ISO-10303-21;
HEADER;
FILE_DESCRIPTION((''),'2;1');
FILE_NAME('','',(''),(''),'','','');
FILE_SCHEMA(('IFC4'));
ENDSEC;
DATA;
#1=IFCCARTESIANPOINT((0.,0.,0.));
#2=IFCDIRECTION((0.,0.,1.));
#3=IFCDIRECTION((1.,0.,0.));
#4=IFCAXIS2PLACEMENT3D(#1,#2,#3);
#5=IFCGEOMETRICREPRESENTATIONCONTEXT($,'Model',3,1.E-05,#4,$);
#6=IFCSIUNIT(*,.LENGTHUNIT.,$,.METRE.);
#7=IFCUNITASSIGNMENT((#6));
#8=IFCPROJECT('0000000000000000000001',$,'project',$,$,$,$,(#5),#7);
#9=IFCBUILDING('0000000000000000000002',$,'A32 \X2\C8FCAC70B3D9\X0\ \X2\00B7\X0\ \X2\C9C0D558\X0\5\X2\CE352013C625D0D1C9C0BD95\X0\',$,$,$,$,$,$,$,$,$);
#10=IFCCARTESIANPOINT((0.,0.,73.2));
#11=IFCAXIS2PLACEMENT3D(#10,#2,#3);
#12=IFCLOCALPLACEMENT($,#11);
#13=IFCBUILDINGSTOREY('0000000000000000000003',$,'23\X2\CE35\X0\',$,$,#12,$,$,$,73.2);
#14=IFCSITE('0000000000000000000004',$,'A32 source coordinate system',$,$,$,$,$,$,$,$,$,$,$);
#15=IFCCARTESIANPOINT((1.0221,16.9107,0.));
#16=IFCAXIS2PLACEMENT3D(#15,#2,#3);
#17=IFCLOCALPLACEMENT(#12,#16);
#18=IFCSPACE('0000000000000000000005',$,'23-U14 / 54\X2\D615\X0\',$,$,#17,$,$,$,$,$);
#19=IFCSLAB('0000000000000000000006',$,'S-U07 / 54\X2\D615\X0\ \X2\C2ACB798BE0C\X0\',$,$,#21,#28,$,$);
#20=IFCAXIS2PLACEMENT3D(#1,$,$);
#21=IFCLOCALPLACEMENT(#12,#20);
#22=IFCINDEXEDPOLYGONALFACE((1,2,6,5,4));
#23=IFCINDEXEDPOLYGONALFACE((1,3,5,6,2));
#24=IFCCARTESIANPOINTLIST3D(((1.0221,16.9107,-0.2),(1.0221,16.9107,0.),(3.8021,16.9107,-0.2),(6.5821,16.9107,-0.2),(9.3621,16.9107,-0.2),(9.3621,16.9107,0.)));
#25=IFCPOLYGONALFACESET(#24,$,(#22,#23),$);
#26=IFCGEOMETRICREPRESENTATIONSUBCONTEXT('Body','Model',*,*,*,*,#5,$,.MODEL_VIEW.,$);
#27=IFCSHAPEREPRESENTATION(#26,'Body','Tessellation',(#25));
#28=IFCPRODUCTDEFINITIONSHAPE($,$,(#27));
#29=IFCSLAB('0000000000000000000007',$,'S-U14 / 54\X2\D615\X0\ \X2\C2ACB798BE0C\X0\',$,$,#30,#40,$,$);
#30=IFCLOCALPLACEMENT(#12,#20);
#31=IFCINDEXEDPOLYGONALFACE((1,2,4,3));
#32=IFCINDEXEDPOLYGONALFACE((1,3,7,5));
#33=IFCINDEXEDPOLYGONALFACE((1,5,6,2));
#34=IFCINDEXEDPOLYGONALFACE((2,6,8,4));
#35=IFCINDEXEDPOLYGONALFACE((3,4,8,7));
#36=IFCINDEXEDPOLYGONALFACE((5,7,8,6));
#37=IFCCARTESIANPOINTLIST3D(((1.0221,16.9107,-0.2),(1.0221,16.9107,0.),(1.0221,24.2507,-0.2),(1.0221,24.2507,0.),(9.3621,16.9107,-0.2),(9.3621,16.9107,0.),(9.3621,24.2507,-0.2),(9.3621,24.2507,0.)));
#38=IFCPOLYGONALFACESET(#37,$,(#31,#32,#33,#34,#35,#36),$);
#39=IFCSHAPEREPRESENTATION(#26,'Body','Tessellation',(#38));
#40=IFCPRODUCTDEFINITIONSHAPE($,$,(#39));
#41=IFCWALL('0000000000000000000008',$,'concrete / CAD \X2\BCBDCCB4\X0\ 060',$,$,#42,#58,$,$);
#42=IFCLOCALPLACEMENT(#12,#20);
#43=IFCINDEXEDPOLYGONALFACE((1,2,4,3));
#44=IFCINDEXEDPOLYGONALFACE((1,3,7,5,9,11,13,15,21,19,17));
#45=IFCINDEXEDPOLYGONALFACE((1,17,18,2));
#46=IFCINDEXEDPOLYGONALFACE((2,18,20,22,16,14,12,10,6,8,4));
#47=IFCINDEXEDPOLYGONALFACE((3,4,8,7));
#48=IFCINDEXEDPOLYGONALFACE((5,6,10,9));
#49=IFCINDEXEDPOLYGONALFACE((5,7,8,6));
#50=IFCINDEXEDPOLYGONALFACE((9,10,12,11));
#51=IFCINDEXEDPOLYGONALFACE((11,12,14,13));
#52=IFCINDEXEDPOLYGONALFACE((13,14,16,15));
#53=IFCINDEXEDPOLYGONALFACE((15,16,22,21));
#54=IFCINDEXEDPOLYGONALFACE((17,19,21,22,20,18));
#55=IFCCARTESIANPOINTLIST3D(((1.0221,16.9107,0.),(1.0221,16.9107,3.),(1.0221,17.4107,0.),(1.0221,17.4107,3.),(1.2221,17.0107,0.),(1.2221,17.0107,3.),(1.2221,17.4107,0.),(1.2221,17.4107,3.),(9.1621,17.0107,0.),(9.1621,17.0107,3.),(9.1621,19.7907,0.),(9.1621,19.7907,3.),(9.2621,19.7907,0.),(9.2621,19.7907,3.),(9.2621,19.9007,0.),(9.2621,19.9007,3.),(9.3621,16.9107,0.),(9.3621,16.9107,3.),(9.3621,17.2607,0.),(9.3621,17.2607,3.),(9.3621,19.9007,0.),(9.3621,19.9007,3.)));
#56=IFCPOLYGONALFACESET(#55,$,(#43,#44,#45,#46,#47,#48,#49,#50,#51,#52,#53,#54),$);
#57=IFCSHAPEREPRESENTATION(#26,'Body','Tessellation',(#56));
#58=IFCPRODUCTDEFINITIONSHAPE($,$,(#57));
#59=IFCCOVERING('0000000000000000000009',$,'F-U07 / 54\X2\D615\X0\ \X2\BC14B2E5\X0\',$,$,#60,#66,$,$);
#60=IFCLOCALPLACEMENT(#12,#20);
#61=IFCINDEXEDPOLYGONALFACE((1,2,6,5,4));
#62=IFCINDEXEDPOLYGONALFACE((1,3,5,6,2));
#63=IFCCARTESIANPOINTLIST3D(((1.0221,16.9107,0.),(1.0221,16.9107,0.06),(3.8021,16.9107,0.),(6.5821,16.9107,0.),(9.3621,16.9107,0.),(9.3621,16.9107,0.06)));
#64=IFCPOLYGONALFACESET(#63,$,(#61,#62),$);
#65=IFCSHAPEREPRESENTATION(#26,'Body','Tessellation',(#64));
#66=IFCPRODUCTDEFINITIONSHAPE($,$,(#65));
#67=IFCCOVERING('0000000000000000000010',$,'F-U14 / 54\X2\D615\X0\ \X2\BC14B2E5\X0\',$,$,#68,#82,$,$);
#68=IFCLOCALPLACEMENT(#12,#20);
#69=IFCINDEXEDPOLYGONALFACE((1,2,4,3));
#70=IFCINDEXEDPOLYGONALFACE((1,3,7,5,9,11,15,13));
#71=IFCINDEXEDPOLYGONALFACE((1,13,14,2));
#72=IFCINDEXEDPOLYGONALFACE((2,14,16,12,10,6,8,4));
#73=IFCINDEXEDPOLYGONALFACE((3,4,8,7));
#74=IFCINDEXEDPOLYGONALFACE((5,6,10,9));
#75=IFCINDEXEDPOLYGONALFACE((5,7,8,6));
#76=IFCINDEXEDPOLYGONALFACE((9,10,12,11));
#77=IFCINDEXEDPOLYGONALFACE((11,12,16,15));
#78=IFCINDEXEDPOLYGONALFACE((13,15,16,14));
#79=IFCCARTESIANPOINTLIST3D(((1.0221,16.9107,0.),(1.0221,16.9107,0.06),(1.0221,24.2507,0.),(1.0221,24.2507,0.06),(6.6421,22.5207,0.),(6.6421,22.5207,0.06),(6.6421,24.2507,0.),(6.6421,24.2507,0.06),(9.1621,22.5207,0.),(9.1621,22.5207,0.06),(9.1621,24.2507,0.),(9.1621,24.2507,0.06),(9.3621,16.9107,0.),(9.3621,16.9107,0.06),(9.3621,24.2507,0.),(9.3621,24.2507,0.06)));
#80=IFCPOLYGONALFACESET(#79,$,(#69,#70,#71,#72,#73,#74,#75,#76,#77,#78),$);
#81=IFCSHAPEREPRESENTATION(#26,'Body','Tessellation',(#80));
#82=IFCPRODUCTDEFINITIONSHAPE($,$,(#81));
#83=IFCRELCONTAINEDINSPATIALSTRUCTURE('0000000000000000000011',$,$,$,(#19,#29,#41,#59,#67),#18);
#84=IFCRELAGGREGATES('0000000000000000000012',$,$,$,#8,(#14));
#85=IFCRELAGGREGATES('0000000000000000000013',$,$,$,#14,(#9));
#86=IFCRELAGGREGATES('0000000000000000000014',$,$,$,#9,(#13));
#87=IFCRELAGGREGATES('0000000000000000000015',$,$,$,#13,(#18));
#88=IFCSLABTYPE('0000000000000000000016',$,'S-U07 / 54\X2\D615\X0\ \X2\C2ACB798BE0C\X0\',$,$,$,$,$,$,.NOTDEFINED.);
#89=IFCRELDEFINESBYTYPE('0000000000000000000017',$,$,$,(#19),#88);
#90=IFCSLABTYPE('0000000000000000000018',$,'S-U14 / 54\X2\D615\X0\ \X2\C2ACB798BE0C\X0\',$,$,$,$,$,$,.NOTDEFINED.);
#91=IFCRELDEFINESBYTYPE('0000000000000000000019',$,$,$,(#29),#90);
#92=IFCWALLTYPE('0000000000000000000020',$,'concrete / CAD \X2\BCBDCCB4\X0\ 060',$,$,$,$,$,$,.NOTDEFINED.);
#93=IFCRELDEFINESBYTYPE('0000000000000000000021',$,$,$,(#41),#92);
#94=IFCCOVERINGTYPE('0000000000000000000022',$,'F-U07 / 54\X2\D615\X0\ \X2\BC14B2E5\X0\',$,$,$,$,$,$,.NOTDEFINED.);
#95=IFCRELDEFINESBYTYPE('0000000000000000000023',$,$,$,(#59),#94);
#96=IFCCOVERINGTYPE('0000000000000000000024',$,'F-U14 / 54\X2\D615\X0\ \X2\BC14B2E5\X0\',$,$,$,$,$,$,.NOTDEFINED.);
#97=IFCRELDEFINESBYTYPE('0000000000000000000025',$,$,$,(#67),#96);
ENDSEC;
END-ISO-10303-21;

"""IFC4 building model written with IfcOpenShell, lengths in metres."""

from ifc_helpers import new_model, si_unit, frame, origin, origin_with_axes, place, context, subcontext, project, spatial, polyline, outline, extrude, source, transform, mapped, type_object, type_shapes, element, save


model = new_model("IFC4")

# Units and contexts
model_context = context("Model", 3, precision=1e-05, world=origin_with_axes())
body_context = subcontext(model_context, "Body", "Model", "MODEL_VIEW")
ifc_project = project(units=[si_unit("LENGTHUNIT", "METRE")], contexts=[model_context])

# Site, building, storey, space
storey_placement = place(None, frame((0.0, 0.0, 73.2), z_axis=(0.0, 0.0, 1.0), x_axis=(1.0, 0.0, 0.0)))
space_placement = place(storey_placement, frame((1.0221, 16.9107, 0.0), z_axis=(0.0, 0.0, 1.0), x_axis=(1.0, 0.0, 0.0)))
site = spatial("IfcSite", under=ifc_project, Name="A32 source coordinate system")
building = spatial("IfcBuilding", under=site, Name="A32 주거동 · 지하5층–옥탑지붕")
storey = spatial("IfcBuildingStorey", under=building, at=storey_placement, Name="23층", Elevation=73.2)
space = spatial("IfcSpace", under=storey, at=space_placement, Name="23-U14 / 54형")

# Slabs
slab_type_1 = type_object("IfcSlabType", Name="S-U07 / 54형 슬래브", PredefinedType="NOTDEFINED")
shared_shape_1 = source(origin(), body_context, "Body", "SweptSolid", [
    extrude(outline(polyline([(0.0, 0.0), (0.0, 0.0), (8.34, 0.0), (8.34, 0.0), (0.0, 0.0)])), frame((0.0, 0.0, -0.2)), (0.0, 0.0, 1.0), 0.2),
])
type_shapes(slab_type_1, [shared_shape_1])
slab_1_placement = place(space_placement, origin_with_axes())
element("IfcSlab", 1, at=slab_1_placement, inside=space, type_object=slab_type_1, Name="S-U07 / 54형 슬래브", context=body_context, shape_type="MappedRepresentation", body=[
    mapped(shared_shape_1, transform((0.0, 0.0, 0.0), scale=1.0)),
])
slab_type_2 = type_object("IfcSlabType", Name="S-U14 / 54형 슬래브", PredefinedType="NOTDEFINED")
shared_shape_2 = source(origin(), body_context, "Body", "SweptSolid", [
    extrude(outline(polyline([(0.0, 0.0), (0.0, 7.34), (8.34, 7.34), (8.34, 0.0), (0.0, 0.0)])), frame((0.0, 0.0, -0.2)), (0.0, 0.0, 1.0), 0.2),
])
type_shapes(slab_type_2, [shared_shape_2])
slab_2_placement = place(space_placement, origin_with_axes())
element("IfcSlab", 2, at=slab_2_placement, inside=space, type_object=slab_type_2, Name="S-U14 / 54형 슬래브", context=body_context, shape_type="MappedRepresentation", body=[
    mapped(shared_shape_2, transform((0.0, 0.0, 0.0), scale=1.0)),
])

# Wall
wall_type_1 = type_object("IfcWallType", Name="concrete / CAD 벽체 060", PredefinedType="NOTDEFINED")
shared_shape_3 = source(origin(), body_context, "Body", "SweptSolid", [
    extrude(outline(polyline([(0.2, 0.5), (0.2, 0.1), (8.14, 0.1), (8.14, 2.88), (8.24, 2.88), (8.24, 2.99), (8.34, 2.99), (8.34, 0.35), (8.34, 0.35), (8.34, 0.0), (0.0, 0.0), (0.0, 0.5), (0.2, 0.5)])), origin(), (0.0, 0.0, 1.0), 3.0),
])
type_shapes(wall_type_1, [shared_shape_3])
wall_1_placement = place(space_placement, origin_with_axes())
element("IfcWall", 3, at=wall_1_placement, inside=space, type_object=wall_type_1, Name="concrete / CAD 벽체 060", context=body_context, shape_type="MappedRepresentation", body=[
    mapped(shared_shape_3, transform((0.0, 0.0, 0.0), scale=1.0)),
])

# Coverings
covering_type_1 = type_object("IfcCoveringType", Name="F-U07 / 54형 바닥", PredefinedType="NOTDEFINED")
shared_shape_4 = source(origin(), body_context, "Body", "SweptSolid", [
    extrude(outline(polyline([(0.0, 0.0), (0.0, 0.0), (8.34, 0.0), (8.34, 0.0), (0.0, 0.0)])), origin(), (0.0, 0.0, 1.0), 0.06),
])
type_shapes(covering_type_1, [shared_shape_4])
covering_1_placement = place(space_placement, origin_with_axes())
element("IfcCovering", 4, at=covering_1_placement, inside=space, type_object=covering_type_1, Name="F-U07 / 54형 바닥", context=body_context, shape_type="MappedRepresentation", body=[
    mapped(shared_shape_4, transform((0.0, 0.0, 0.0), scale=1.0)),
])
covering_type_2 = type_object("IfcCoveringType", Name="F-U14 / 54형 바닥", PredefinedType="NOTDEFINED")
shared_shape_5 = source(origin(), body_context, "Body", "SweptSolid", [
    extrude(outline(polyline([(8.14, 7.34), (8.34, 7.34), (8.34, 0.0), (0.0, 0.0), (0.0, 7.34), (5.62, 7.34), (5.62, 5.61), (8.14, 5.61), (8.14, 7.34)])), origin(), (0.0, 0.0, 1.0), 0.06),
])
type_shapes(covering_type_2, [shared_shape_5])
covering_2_placement = place(space_placement, origin_with_axes())
element("IfcCovering", 5, at=covering_2_placement, inside=space, type_object=covering_type_2, Name="F-U14 / 54형 바닥", context=body_context, shape_type="MappedRepresentation", body=[
    mapped(shared_shape_5, transform((0.0, 0.0, 0.0), scale=1.0)),
])

save(model, "model.ifc")
